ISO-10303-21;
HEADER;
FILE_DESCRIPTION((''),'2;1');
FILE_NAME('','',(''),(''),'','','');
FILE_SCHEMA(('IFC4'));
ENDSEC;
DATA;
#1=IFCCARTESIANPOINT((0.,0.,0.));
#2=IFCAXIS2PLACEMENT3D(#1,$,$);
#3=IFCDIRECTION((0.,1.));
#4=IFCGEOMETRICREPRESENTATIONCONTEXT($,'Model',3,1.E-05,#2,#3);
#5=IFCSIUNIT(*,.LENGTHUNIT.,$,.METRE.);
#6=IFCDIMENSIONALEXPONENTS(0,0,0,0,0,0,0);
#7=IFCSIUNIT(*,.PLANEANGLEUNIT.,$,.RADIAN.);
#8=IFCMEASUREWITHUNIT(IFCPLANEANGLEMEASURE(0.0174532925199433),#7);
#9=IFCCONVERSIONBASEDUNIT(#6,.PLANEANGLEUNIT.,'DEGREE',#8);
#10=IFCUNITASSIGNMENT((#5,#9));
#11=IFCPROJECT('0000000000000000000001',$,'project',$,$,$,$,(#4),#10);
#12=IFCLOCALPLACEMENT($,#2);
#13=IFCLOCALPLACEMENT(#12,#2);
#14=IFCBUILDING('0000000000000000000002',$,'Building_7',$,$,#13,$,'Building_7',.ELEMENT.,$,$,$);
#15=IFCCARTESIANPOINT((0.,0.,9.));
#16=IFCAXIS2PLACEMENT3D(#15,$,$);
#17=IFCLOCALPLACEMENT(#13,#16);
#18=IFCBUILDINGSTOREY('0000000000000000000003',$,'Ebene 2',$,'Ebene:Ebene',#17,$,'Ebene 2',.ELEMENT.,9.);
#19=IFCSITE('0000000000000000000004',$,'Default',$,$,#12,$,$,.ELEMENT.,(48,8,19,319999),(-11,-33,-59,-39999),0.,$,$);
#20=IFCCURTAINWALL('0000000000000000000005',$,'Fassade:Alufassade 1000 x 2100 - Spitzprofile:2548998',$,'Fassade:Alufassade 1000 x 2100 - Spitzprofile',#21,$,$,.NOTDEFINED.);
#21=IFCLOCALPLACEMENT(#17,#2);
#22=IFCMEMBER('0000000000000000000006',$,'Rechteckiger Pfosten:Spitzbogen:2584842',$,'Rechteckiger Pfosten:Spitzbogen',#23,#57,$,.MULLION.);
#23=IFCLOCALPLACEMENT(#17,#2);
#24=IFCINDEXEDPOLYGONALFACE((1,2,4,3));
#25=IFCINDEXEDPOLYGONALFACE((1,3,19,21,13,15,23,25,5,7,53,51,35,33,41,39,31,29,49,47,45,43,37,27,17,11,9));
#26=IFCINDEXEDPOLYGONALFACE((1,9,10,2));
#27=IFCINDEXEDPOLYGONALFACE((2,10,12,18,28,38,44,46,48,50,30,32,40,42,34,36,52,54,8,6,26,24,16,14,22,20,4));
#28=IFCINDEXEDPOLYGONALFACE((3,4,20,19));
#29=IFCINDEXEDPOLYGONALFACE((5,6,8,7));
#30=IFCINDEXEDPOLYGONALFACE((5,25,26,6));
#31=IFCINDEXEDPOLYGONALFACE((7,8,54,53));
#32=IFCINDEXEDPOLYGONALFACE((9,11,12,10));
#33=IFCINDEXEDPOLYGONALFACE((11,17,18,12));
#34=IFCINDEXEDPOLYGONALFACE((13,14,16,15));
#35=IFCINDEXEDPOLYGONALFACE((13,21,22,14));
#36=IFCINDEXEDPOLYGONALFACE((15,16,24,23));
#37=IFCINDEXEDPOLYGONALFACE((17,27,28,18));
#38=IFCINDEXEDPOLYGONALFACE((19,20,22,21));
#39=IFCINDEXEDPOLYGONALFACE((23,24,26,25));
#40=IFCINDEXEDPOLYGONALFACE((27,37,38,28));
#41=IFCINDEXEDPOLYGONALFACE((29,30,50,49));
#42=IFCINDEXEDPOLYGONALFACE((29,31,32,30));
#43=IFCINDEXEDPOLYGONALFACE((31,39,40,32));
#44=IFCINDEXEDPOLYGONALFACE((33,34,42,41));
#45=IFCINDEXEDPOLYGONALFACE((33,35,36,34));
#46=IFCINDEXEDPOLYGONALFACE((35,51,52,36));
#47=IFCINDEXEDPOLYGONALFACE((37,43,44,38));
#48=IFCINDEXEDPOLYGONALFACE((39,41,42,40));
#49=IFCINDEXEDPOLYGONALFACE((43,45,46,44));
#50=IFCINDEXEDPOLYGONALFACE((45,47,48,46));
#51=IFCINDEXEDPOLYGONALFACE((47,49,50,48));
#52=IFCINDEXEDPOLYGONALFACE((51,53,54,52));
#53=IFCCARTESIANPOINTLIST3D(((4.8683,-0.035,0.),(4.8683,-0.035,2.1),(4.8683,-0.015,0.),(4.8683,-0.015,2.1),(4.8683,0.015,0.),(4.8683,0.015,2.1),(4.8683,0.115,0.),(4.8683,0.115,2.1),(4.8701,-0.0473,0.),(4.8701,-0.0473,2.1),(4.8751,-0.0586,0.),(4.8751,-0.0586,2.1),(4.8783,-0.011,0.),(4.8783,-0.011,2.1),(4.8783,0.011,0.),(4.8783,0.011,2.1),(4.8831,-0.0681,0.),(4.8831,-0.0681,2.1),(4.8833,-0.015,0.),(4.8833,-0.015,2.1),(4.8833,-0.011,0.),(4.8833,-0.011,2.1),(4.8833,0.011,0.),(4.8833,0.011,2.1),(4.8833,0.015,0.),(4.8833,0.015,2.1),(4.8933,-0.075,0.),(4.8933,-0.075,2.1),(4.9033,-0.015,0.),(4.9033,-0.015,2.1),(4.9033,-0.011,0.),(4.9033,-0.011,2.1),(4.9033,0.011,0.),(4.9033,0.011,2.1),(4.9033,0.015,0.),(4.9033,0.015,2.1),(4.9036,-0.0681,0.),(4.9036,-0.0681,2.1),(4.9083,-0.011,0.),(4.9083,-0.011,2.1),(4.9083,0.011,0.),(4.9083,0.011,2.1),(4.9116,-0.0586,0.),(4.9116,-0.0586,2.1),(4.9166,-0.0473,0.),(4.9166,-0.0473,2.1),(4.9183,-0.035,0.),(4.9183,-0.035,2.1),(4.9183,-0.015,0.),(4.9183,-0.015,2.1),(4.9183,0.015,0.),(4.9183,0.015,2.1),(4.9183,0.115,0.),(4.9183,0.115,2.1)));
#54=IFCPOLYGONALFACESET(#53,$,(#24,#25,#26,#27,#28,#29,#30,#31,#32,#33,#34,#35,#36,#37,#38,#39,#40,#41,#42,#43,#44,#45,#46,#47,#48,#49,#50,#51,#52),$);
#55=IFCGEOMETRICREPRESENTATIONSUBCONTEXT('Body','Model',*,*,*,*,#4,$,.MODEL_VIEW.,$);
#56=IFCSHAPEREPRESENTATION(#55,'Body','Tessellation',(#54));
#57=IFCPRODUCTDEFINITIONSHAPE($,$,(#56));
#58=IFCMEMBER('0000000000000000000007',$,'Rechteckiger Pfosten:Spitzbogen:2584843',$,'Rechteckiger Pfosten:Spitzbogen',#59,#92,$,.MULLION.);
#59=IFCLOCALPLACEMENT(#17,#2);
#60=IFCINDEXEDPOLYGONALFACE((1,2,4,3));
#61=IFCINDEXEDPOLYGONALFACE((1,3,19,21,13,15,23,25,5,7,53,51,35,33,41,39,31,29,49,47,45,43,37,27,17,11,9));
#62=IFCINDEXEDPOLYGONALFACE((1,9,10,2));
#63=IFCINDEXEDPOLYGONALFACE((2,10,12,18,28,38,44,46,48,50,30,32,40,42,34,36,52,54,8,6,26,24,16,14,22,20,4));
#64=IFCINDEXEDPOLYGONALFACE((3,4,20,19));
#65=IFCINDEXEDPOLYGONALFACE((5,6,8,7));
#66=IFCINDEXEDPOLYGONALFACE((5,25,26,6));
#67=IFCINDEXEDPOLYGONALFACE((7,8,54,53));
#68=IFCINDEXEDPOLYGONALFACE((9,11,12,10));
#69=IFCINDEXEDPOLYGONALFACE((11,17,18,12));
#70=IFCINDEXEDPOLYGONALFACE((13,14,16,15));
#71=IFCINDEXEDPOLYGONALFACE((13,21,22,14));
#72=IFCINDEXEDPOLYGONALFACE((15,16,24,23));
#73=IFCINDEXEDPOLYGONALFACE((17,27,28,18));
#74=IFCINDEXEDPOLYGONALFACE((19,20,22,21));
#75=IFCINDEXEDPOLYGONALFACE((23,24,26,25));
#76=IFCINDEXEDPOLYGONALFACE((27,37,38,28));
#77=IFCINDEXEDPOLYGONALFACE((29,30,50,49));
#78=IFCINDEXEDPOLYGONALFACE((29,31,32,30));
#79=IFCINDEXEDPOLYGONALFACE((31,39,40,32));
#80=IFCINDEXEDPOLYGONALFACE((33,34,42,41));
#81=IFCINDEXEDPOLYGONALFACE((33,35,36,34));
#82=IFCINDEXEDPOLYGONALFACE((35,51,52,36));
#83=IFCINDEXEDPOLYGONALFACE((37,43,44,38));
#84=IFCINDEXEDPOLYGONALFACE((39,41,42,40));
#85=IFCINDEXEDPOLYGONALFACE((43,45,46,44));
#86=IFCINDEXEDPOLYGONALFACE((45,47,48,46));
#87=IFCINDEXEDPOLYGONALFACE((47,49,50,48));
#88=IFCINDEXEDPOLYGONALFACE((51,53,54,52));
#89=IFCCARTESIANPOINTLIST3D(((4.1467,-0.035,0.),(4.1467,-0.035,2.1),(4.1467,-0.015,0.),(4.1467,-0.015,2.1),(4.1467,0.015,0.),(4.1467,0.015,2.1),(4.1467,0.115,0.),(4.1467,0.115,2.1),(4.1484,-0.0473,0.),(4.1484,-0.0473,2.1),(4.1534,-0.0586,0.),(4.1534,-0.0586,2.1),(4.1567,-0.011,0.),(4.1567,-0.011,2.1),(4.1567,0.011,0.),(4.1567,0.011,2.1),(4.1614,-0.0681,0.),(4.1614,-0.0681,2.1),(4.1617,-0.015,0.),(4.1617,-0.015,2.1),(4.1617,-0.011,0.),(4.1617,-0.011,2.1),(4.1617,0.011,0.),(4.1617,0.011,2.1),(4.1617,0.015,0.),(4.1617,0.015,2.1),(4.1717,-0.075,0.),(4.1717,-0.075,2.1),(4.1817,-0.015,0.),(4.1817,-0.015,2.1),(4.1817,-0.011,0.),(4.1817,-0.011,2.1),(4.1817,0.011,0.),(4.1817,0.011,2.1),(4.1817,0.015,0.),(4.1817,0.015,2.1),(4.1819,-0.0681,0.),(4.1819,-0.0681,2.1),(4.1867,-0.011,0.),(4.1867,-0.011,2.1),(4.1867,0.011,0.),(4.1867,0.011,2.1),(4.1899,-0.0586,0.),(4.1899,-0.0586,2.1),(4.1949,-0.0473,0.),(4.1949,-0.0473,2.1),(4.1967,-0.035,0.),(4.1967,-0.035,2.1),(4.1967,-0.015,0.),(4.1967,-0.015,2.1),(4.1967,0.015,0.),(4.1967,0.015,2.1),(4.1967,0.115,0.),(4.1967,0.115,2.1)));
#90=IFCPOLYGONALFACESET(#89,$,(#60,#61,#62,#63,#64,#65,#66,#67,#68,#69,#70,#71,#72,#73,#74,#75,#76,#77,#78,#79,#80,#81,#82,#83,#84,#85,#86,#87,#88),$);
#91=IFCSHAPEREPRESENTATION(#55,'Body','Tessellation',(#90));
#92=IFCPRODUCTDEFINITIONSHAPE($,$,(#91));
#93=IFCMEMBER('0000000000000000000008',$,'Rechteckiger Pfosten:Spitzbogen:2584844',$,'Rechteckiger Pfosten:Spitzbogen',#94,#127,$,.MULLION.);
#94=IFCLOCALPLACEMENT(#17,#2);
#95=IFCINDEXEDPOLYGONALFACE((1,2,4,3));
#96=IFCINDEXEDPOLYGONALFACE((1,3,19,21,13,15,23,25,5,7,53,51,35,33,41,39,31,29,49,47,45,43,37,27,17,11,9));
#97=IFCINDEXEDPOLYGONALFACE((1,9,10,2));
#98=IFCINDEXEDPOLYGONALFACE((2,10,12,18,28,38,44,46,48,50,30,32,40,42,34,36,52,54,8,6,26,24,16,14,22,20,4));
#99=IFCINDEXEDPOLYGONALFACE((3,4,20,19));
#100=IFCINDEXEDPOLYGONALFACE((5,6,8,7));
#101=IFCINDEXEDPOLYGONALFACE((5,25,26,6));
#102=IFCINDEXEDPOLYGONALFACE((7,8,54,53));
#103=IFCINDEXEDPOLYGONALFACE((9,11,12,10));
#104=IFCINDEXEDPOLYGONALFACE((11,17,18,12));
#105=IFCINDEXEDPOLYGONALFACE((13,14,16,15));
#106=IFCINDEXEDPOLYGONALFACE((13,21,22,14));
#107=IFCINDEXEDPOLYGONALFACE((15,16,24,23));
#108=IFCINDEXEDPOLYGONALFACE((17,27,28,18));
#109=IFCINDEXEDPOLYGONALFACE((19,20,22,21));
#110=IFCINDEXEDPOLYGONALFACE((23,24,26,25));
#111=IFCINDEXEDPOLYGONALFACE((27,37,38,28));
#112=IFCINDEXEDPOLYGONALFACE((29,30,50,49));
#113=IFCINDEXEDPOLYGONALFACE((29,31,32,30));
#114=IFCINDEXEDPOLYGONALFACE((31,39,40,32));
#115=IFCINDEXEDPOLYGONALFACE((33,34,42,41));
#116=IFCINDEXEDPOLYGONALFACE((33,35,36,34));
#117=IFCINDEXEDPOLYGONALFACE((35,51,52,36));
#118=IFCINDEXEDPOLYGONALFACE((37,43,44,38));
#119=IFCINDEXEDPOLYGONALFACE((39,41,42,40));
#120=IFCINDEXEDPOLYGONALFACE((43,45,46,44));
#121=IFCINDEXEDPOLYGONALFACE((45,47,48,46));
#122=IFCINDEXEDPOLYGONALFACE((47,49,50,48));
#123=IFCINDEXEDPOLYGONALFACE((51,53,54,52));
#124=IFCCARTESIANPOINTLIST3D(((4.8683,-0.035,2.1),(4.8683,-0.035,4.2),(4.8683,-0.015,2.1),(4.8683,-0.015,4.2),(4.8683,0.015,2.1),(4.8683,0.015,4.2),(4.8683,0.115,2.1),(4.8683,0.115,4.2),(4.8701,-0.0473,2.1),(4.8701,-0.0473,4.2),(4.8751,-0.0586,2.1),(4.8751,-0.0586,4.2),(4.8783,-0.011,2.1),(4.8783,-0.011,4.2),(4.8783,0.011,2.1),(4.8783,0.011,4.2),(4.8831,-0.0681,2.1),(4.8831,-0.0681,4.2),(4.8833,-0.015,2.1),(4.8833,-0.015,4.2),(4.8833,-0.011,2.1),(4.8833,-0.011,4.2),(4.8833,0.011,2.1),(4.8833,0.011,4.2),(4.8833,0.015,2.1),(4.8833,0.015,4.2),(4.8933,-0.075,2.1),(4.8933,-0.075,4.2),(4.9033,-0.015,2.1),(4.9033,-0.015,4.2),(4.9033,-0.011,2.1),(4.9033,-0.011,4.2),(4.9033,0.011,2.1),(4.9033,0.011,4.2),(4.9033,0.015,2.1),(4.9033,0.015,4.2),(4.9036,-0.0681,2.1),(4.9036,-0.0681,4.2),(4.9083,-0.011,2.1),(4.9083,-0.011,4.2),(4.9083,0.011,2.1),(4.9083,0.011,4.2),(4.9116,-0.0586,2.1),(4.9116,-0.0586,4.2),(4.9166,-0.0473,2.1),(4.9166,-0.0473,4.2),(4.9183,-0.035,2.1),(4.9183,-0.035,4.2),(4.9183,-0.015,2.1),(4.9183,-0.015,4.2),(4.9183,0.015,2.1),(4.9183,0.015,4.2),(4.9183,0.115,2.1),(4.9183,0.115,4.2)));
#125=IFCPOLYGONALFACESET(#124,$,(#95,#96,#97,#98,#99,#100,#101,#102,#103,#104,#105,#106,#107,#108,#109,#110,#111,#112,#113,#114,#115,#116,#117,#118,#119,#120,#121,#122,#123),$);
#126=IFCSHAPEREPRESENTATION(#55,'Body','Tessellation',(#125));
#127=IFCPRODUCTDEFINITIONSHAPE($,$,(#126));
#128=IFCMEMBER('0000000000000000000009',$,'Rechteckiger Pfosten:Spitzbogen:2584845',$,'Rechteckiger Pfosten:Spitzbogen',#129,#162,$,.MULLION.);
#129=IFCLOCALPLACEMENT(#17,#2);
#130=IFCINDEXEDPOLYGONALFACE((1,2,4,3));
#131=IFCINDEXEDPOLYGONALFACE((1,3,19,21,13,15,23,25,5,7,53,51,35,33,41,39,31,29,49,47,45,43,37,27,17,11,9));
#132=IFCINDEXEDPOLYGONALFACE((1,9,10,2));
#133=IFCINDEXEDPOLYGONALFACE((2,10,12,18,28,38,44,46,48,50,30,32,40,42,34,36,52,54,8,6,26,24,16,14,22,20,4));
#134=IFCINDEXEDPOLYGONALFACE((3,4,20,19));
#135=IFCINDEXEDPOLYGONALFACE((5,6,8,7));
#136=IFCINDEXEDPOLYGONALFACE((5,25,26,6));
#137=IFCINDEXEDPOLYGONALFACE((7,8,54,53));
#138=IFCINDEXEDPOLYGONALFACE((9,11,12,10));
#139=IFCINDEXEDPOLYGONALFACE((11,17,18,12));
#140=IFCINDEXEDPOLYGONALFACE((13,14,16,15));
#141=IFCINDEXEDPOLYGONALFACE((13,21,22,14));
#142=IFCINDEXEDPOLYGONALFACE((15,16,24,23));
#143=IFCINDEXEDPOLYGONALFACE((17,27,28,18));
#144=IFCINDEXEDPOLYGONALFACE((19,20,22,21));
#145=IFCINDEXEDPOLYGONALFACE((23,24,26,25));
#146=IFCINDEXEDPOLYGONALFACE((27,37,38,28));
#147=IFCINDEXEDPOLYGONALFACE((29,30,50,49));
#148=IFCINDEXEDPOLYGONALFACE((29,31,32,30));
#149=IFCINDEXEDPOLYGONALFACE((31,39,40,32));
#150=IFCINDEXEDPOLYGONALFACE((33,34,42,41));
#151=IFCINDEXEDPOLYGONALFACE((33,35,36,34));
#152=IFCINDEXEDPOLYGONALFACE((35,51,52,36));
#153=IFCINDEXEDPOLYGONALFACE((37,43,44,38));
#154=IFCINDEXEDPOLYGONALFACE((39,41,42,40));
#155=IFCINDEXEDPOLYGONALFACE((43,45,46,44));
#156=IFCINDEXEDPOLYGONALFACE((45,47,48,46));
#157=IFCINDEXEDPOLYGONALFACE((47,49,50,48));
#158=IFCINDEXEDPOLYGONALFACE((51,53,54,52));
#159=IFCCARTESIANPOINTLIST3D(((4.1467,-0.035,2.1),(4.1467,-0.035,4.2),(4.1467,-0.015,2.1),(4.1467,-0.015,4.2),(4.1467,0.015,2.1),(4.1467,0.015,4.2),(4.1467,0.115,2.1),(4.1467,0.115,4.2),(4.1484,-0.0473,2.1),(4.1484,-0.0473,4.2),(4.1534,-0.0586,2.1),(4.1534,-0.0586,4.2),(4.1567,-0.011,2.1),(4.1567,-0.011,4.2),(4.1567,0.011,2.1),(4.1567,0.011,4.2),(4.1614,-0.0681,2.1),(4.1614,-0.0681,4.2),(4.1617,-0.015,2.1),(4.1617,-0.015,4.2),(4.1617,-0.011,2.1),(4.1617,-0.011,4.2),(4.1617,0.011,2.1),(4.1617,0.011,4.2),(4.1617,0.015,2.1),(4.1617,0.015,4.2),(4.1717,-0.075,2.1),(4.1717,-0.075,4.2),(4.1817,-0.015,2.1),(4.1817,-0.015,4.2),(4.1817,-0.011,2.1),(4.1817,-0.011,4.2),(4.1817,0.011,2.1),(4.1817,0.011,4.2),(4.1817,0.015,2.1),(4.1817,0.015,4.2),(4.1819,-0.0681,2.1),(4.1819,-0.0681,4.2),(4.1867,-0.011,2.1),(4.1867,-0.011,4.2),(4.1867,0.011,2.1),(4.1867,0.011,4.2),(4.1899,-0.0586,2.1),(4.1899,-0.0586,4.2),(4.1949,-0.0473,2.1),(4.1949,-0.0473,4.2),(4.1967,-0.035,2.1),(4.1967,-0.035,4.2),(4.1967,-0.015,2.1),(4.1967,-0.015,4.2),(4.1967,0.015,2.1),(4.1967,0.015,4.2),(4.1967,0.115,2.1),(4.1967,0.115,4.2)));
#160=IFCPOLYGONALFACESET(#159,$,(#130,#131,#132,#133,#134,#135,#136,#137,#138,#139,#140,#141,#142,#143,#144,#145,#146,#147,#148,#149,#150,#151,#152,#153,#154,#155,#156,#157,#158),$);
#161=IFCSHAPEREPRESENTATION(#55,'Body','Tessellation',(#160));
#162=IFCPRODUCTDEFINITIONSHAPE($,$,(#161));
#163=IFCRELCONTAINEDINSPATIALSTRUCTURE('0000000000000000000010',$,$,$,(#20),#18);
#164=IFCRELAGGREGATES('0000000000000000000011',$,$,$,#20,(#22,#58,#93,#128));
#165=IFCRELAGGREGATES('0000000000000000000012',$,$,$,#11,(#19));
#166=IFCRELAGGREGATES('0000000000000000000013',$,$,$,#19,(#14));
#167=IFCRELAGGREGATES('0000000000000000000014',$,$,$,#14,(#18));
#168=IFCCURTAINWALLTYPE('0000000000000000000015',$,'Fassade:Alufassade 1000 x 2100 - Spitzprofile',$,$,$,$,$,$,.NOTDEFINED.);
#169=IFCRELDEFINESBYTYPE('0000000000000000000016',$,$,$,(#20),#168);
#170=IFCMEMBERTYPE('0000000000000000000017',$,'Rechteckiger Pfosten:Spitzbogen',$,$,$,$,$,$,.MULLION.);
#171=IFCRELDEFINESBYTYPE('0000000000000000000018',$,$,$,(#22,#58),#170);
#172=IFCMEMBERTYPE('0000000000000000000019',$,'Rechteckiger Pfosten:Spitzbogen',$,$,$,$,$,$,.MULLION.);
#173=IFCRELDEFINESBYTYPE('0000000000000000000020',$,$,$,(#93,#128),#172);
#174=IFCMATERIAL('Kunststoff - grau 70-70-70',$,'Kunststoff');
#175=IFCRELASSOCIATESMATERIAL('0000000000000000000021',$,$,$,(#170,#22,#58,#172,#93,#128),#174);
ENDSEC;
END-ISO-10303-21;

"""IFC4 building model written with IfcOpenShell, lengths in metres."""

from ifc_helpers import new_model, entity, si_unit, converted_unit, direction, frame, origin, place, context, subcontext, project, spatial, line, arc, indexed_curve, outline, extrude, source, transform, mapped, material, type_object, type_shapes, element, aggregate, save


model = new_model("IFC4")

# Units and contexts
model_context = context("Model", 3, precision=1e-05, world=origin(), true_north=direction((0.0, 1.0)))
body_context = subcontext(model_context, "Body", "Model", "MODEL_VIEW")
ifc_project = project(units=[si_unit("LENGTHUNIT", "METRE"), converted_unit("PLANEANGLEUNIT", "DEGREE", entity("IfcPlaneAngleMeasure", 0.0174532925199433), si_unit("PLANEANGLEUNIT", "RADIAN"), dimensions=[0, 0, 0, 0, 0, 0, 0])], contexts=[model_context])

# Site, building, storey
site_placement = place(None, origin())
site = spatial("IfcSite", under=ifc_project, at=site_placement, Name="Default", CompositionType="ELEMENT", RefLatitude=(48, 8, 19, 319999), RefLongitude=(-11, -33, -59, -39999), RefElevation=0.0)
building_placement = place(site_placement, origin())
building = spatial("IfcBuilding", under=site, at=building_placement, Name="Building_7", LongName="Building_7", CompositionType="ELEMENT")
storey_placement = place(building_placement, frame((0.0, 0.0, 9.0)))
storey = spatial("IfcBuildingStorey", under=building, at=storey_placement, Name="Ebene 2", ObjectType="Ebene:Ebene", LongName="Ebene 2", CompositionType="ELEMENT", Elevation=9.0)

# Curtain wall, members
curtain_wall_type = type_object("IfcCurtainWallType", Name="Fassade:Alufassade 1000 x 2100 - Spitzprofile", PredefinedType="NOTDEFINED")
curtain_wall_placement = place(storey_placement, frame((0.0, 0.0, -9.0)))
curtain_wall = element("IfcCurtainWall", 1, at=curtain_wall_placement, inside=storey, type_object=curtain_wall_type, Name="Fassade:Alufassade 1000 x 2100 - Spitzprofile:2548998", ObjectType="Fassade:Alufassade 1000 x 2100 - Spitzprofile", PredefinedType="NOTDEFINED")
ifc_material_1 = material(Name="Kunststoff - grau 70-70-70", Category="Kunststoff")
member_type_1 = type_object("IfcMemberType", Name="Rechteckiger Pfosten:Spitzbogen", PredefinedType="MULLION", material=ifc_material_1)
shared_shape_1 = source(origin(), body_context, "Body", "SweptSolid", [
    extrude(outline(indexed_curve([(-0.111, -0.025), (-0.011, -0.025), (-0.011, -0.01), (-0.007, -0.01), (-0.007, -0.015), (0.015, -0.015), (0.015, -0.01), (0.019, -0.01), (0.019, -0.025), (0.039, -0.025), (0.0626, -0.0182), (0.079, 0.0), (0.0626, 0.0182), (0.039, 0.025), (0.019, 0.025), (0.019, 0.01), (0.015, 0.01), (0.015, 0.015), (-0.007, 0.015), (-0.007, 0.01), (-0.011, 0.01), (-0.011, 0.025), (-0.111, 0.025)], segments=[line(1, 2, 3, 4, 5, 6, 7, 8, 9, 10), arc(10, 11, 12), arc(12, 13, 14), line(14, 15, 16, 17, 18, 19, 20, 21, 22, 23, 1)], self_intersect=False)), frame((0.0, 0.004, -2.1), z_axis=(0.0, 0.0, 1.0), x_axis=(0.0, -1.0, 0.0)), (0.0, 0.0, 1.0), 2.1),
])
type_shapes(member_type_1, [shared_shape_1])
member_1_placement = place(curtain_wall_placement, frame((4.8933, 0.0, 9.0), z_axis=(0.0, 0.0, -1.0), x_axis=(-1.0, 0.0, 0.0)))
member_1 = element("IfcMember", 2, at=member_1_placement, type_object=member_type_1, material=ifc_material_1, Name="Rechteckiger Pfosten:Spitzbogen:2584842", ObjectType="Rechteckiger Pfosten:Spitzbogen", PredefinedType="MULLION", context=body_context, shape_type="MappedRepresentation", body=[
    mapped(shared_shape_1, transform((0.0, 0.0, 0.0), scale=1.0)),
])
member_2_placement = place(curtain_wall_placement, frame((4.1717, 0.0, 9.0), z_axis=(0.0, 0.0, -1.0), x_axis=(-1.0, 0.0, 0.0)))
member_2 = element("IfcMember", 3, at=member_2_placement, type_object=member_type_1, material=ifc_material_1, Name="Rechteckiger Pfosten:Spitzbogen:2584843", ObjectType="Rechteckiger Pfosten:Spitzbogen", PredefinedType="MULLION", context=body_context, shape_type="MappedRepresentation", body=[
    mapped(shared_shape_1, transform((0.0, 0.0, 0.0), scale=1.0)),
])
member_type_2 = type_object("IfcMemberType", Name="Rechteckiger Pfosten:Spitzbogen", PredefinedType="MULLION", material=ifc_material_1)
shared_shape_2 = source(origin(), body_context, "Body", "SweptSolid", [
    extrude(outline(indexed_curve([(-0.111, -0.025), (-0.011, -0.025), (-0.011, -0.01), (-0.007, -0.01), (-0.007, -0.015), (0.015, -0.015), (0.015, -0.01), (0.019, -0.01), (0.019, -0.025), (0.039, -0.025), (0.0626, -0.0182), (0.079, 0.0), (0.0626, 0.0182), (0.039, 0.025), (0.019, 0.025), (0.019, 0.01), (0.015, 0.01), (0.015, 0.015), (-0.007, 0.015), (-0.007, 0.01), (-0.011, 0.01), (-0.011, 0.025), (-0.111, 0.025)], segments=[line(1, 2, 3, 4, 5, 6, 7, 8, 9, 10), arc(10, 11, 12), arc(12, 13, 14), line(14, 15, 16, 17, 18, 19, 20, 21, 22, 23, 1)], self_intersect=False)), frame((0.0, 0.004, -2.1), z_axis=(0.0, 0.0, 1.0), x_axis=(0.0, -1.0, 0.0)), (0.0, 0.0, 1.0), 2.1),
])
type_shapes(member_type_2, [shared_shape_2])
member_3_placement = place(curtain_wall_placement, frame((4.8933, 0.0, 11.1), z_axis=(0.0, 0.0, -1.0), x_axis=(-1.0, 0.0, 0.0)))
member_3 = element("IfcMember", 4, at=member_3_placement, type_object=member_type_2, material=ifc_material_1, Name="Rechteckiger Pfosten:Spitzbogen:2584844", ObjectType="Rechteckiger Pfosten:Spitzbogen", PredefinedType="MULLION", context=body_context, shape_type="MappedRepresentation", body=[
    mapped(shared_shape_2, transform((0.0, 0.0, 0.0), scale=1.0)),
])
member_4_placement = place(curtain_wall_placement, frame((4.1717, 0.0, 11.1), z_axis=(0.0, 0.0, -1.0), x_axis=(-1.0, 0.0, 0.0)))
member_4 = element("IfcMember", 5, at=member_4_placement, type_object=member_type_2, material=ifc_material_1, Name="Rechteckiger Pfosten:Spitzbogen:2584845", ObjectType="Rechteckiger Pfosten:Spitzbogen", PredefinedType="MULLION", context=body_context, shape_type="MappedRepresentation", body=[
    mapped(shared_shape_2, transform((0.0, 0.0, 0.0), scale=1.0)),
])

aggregate(curtain_wall, [member_1, member_2, member_3, member_4])

save(model, "model.ifc")
